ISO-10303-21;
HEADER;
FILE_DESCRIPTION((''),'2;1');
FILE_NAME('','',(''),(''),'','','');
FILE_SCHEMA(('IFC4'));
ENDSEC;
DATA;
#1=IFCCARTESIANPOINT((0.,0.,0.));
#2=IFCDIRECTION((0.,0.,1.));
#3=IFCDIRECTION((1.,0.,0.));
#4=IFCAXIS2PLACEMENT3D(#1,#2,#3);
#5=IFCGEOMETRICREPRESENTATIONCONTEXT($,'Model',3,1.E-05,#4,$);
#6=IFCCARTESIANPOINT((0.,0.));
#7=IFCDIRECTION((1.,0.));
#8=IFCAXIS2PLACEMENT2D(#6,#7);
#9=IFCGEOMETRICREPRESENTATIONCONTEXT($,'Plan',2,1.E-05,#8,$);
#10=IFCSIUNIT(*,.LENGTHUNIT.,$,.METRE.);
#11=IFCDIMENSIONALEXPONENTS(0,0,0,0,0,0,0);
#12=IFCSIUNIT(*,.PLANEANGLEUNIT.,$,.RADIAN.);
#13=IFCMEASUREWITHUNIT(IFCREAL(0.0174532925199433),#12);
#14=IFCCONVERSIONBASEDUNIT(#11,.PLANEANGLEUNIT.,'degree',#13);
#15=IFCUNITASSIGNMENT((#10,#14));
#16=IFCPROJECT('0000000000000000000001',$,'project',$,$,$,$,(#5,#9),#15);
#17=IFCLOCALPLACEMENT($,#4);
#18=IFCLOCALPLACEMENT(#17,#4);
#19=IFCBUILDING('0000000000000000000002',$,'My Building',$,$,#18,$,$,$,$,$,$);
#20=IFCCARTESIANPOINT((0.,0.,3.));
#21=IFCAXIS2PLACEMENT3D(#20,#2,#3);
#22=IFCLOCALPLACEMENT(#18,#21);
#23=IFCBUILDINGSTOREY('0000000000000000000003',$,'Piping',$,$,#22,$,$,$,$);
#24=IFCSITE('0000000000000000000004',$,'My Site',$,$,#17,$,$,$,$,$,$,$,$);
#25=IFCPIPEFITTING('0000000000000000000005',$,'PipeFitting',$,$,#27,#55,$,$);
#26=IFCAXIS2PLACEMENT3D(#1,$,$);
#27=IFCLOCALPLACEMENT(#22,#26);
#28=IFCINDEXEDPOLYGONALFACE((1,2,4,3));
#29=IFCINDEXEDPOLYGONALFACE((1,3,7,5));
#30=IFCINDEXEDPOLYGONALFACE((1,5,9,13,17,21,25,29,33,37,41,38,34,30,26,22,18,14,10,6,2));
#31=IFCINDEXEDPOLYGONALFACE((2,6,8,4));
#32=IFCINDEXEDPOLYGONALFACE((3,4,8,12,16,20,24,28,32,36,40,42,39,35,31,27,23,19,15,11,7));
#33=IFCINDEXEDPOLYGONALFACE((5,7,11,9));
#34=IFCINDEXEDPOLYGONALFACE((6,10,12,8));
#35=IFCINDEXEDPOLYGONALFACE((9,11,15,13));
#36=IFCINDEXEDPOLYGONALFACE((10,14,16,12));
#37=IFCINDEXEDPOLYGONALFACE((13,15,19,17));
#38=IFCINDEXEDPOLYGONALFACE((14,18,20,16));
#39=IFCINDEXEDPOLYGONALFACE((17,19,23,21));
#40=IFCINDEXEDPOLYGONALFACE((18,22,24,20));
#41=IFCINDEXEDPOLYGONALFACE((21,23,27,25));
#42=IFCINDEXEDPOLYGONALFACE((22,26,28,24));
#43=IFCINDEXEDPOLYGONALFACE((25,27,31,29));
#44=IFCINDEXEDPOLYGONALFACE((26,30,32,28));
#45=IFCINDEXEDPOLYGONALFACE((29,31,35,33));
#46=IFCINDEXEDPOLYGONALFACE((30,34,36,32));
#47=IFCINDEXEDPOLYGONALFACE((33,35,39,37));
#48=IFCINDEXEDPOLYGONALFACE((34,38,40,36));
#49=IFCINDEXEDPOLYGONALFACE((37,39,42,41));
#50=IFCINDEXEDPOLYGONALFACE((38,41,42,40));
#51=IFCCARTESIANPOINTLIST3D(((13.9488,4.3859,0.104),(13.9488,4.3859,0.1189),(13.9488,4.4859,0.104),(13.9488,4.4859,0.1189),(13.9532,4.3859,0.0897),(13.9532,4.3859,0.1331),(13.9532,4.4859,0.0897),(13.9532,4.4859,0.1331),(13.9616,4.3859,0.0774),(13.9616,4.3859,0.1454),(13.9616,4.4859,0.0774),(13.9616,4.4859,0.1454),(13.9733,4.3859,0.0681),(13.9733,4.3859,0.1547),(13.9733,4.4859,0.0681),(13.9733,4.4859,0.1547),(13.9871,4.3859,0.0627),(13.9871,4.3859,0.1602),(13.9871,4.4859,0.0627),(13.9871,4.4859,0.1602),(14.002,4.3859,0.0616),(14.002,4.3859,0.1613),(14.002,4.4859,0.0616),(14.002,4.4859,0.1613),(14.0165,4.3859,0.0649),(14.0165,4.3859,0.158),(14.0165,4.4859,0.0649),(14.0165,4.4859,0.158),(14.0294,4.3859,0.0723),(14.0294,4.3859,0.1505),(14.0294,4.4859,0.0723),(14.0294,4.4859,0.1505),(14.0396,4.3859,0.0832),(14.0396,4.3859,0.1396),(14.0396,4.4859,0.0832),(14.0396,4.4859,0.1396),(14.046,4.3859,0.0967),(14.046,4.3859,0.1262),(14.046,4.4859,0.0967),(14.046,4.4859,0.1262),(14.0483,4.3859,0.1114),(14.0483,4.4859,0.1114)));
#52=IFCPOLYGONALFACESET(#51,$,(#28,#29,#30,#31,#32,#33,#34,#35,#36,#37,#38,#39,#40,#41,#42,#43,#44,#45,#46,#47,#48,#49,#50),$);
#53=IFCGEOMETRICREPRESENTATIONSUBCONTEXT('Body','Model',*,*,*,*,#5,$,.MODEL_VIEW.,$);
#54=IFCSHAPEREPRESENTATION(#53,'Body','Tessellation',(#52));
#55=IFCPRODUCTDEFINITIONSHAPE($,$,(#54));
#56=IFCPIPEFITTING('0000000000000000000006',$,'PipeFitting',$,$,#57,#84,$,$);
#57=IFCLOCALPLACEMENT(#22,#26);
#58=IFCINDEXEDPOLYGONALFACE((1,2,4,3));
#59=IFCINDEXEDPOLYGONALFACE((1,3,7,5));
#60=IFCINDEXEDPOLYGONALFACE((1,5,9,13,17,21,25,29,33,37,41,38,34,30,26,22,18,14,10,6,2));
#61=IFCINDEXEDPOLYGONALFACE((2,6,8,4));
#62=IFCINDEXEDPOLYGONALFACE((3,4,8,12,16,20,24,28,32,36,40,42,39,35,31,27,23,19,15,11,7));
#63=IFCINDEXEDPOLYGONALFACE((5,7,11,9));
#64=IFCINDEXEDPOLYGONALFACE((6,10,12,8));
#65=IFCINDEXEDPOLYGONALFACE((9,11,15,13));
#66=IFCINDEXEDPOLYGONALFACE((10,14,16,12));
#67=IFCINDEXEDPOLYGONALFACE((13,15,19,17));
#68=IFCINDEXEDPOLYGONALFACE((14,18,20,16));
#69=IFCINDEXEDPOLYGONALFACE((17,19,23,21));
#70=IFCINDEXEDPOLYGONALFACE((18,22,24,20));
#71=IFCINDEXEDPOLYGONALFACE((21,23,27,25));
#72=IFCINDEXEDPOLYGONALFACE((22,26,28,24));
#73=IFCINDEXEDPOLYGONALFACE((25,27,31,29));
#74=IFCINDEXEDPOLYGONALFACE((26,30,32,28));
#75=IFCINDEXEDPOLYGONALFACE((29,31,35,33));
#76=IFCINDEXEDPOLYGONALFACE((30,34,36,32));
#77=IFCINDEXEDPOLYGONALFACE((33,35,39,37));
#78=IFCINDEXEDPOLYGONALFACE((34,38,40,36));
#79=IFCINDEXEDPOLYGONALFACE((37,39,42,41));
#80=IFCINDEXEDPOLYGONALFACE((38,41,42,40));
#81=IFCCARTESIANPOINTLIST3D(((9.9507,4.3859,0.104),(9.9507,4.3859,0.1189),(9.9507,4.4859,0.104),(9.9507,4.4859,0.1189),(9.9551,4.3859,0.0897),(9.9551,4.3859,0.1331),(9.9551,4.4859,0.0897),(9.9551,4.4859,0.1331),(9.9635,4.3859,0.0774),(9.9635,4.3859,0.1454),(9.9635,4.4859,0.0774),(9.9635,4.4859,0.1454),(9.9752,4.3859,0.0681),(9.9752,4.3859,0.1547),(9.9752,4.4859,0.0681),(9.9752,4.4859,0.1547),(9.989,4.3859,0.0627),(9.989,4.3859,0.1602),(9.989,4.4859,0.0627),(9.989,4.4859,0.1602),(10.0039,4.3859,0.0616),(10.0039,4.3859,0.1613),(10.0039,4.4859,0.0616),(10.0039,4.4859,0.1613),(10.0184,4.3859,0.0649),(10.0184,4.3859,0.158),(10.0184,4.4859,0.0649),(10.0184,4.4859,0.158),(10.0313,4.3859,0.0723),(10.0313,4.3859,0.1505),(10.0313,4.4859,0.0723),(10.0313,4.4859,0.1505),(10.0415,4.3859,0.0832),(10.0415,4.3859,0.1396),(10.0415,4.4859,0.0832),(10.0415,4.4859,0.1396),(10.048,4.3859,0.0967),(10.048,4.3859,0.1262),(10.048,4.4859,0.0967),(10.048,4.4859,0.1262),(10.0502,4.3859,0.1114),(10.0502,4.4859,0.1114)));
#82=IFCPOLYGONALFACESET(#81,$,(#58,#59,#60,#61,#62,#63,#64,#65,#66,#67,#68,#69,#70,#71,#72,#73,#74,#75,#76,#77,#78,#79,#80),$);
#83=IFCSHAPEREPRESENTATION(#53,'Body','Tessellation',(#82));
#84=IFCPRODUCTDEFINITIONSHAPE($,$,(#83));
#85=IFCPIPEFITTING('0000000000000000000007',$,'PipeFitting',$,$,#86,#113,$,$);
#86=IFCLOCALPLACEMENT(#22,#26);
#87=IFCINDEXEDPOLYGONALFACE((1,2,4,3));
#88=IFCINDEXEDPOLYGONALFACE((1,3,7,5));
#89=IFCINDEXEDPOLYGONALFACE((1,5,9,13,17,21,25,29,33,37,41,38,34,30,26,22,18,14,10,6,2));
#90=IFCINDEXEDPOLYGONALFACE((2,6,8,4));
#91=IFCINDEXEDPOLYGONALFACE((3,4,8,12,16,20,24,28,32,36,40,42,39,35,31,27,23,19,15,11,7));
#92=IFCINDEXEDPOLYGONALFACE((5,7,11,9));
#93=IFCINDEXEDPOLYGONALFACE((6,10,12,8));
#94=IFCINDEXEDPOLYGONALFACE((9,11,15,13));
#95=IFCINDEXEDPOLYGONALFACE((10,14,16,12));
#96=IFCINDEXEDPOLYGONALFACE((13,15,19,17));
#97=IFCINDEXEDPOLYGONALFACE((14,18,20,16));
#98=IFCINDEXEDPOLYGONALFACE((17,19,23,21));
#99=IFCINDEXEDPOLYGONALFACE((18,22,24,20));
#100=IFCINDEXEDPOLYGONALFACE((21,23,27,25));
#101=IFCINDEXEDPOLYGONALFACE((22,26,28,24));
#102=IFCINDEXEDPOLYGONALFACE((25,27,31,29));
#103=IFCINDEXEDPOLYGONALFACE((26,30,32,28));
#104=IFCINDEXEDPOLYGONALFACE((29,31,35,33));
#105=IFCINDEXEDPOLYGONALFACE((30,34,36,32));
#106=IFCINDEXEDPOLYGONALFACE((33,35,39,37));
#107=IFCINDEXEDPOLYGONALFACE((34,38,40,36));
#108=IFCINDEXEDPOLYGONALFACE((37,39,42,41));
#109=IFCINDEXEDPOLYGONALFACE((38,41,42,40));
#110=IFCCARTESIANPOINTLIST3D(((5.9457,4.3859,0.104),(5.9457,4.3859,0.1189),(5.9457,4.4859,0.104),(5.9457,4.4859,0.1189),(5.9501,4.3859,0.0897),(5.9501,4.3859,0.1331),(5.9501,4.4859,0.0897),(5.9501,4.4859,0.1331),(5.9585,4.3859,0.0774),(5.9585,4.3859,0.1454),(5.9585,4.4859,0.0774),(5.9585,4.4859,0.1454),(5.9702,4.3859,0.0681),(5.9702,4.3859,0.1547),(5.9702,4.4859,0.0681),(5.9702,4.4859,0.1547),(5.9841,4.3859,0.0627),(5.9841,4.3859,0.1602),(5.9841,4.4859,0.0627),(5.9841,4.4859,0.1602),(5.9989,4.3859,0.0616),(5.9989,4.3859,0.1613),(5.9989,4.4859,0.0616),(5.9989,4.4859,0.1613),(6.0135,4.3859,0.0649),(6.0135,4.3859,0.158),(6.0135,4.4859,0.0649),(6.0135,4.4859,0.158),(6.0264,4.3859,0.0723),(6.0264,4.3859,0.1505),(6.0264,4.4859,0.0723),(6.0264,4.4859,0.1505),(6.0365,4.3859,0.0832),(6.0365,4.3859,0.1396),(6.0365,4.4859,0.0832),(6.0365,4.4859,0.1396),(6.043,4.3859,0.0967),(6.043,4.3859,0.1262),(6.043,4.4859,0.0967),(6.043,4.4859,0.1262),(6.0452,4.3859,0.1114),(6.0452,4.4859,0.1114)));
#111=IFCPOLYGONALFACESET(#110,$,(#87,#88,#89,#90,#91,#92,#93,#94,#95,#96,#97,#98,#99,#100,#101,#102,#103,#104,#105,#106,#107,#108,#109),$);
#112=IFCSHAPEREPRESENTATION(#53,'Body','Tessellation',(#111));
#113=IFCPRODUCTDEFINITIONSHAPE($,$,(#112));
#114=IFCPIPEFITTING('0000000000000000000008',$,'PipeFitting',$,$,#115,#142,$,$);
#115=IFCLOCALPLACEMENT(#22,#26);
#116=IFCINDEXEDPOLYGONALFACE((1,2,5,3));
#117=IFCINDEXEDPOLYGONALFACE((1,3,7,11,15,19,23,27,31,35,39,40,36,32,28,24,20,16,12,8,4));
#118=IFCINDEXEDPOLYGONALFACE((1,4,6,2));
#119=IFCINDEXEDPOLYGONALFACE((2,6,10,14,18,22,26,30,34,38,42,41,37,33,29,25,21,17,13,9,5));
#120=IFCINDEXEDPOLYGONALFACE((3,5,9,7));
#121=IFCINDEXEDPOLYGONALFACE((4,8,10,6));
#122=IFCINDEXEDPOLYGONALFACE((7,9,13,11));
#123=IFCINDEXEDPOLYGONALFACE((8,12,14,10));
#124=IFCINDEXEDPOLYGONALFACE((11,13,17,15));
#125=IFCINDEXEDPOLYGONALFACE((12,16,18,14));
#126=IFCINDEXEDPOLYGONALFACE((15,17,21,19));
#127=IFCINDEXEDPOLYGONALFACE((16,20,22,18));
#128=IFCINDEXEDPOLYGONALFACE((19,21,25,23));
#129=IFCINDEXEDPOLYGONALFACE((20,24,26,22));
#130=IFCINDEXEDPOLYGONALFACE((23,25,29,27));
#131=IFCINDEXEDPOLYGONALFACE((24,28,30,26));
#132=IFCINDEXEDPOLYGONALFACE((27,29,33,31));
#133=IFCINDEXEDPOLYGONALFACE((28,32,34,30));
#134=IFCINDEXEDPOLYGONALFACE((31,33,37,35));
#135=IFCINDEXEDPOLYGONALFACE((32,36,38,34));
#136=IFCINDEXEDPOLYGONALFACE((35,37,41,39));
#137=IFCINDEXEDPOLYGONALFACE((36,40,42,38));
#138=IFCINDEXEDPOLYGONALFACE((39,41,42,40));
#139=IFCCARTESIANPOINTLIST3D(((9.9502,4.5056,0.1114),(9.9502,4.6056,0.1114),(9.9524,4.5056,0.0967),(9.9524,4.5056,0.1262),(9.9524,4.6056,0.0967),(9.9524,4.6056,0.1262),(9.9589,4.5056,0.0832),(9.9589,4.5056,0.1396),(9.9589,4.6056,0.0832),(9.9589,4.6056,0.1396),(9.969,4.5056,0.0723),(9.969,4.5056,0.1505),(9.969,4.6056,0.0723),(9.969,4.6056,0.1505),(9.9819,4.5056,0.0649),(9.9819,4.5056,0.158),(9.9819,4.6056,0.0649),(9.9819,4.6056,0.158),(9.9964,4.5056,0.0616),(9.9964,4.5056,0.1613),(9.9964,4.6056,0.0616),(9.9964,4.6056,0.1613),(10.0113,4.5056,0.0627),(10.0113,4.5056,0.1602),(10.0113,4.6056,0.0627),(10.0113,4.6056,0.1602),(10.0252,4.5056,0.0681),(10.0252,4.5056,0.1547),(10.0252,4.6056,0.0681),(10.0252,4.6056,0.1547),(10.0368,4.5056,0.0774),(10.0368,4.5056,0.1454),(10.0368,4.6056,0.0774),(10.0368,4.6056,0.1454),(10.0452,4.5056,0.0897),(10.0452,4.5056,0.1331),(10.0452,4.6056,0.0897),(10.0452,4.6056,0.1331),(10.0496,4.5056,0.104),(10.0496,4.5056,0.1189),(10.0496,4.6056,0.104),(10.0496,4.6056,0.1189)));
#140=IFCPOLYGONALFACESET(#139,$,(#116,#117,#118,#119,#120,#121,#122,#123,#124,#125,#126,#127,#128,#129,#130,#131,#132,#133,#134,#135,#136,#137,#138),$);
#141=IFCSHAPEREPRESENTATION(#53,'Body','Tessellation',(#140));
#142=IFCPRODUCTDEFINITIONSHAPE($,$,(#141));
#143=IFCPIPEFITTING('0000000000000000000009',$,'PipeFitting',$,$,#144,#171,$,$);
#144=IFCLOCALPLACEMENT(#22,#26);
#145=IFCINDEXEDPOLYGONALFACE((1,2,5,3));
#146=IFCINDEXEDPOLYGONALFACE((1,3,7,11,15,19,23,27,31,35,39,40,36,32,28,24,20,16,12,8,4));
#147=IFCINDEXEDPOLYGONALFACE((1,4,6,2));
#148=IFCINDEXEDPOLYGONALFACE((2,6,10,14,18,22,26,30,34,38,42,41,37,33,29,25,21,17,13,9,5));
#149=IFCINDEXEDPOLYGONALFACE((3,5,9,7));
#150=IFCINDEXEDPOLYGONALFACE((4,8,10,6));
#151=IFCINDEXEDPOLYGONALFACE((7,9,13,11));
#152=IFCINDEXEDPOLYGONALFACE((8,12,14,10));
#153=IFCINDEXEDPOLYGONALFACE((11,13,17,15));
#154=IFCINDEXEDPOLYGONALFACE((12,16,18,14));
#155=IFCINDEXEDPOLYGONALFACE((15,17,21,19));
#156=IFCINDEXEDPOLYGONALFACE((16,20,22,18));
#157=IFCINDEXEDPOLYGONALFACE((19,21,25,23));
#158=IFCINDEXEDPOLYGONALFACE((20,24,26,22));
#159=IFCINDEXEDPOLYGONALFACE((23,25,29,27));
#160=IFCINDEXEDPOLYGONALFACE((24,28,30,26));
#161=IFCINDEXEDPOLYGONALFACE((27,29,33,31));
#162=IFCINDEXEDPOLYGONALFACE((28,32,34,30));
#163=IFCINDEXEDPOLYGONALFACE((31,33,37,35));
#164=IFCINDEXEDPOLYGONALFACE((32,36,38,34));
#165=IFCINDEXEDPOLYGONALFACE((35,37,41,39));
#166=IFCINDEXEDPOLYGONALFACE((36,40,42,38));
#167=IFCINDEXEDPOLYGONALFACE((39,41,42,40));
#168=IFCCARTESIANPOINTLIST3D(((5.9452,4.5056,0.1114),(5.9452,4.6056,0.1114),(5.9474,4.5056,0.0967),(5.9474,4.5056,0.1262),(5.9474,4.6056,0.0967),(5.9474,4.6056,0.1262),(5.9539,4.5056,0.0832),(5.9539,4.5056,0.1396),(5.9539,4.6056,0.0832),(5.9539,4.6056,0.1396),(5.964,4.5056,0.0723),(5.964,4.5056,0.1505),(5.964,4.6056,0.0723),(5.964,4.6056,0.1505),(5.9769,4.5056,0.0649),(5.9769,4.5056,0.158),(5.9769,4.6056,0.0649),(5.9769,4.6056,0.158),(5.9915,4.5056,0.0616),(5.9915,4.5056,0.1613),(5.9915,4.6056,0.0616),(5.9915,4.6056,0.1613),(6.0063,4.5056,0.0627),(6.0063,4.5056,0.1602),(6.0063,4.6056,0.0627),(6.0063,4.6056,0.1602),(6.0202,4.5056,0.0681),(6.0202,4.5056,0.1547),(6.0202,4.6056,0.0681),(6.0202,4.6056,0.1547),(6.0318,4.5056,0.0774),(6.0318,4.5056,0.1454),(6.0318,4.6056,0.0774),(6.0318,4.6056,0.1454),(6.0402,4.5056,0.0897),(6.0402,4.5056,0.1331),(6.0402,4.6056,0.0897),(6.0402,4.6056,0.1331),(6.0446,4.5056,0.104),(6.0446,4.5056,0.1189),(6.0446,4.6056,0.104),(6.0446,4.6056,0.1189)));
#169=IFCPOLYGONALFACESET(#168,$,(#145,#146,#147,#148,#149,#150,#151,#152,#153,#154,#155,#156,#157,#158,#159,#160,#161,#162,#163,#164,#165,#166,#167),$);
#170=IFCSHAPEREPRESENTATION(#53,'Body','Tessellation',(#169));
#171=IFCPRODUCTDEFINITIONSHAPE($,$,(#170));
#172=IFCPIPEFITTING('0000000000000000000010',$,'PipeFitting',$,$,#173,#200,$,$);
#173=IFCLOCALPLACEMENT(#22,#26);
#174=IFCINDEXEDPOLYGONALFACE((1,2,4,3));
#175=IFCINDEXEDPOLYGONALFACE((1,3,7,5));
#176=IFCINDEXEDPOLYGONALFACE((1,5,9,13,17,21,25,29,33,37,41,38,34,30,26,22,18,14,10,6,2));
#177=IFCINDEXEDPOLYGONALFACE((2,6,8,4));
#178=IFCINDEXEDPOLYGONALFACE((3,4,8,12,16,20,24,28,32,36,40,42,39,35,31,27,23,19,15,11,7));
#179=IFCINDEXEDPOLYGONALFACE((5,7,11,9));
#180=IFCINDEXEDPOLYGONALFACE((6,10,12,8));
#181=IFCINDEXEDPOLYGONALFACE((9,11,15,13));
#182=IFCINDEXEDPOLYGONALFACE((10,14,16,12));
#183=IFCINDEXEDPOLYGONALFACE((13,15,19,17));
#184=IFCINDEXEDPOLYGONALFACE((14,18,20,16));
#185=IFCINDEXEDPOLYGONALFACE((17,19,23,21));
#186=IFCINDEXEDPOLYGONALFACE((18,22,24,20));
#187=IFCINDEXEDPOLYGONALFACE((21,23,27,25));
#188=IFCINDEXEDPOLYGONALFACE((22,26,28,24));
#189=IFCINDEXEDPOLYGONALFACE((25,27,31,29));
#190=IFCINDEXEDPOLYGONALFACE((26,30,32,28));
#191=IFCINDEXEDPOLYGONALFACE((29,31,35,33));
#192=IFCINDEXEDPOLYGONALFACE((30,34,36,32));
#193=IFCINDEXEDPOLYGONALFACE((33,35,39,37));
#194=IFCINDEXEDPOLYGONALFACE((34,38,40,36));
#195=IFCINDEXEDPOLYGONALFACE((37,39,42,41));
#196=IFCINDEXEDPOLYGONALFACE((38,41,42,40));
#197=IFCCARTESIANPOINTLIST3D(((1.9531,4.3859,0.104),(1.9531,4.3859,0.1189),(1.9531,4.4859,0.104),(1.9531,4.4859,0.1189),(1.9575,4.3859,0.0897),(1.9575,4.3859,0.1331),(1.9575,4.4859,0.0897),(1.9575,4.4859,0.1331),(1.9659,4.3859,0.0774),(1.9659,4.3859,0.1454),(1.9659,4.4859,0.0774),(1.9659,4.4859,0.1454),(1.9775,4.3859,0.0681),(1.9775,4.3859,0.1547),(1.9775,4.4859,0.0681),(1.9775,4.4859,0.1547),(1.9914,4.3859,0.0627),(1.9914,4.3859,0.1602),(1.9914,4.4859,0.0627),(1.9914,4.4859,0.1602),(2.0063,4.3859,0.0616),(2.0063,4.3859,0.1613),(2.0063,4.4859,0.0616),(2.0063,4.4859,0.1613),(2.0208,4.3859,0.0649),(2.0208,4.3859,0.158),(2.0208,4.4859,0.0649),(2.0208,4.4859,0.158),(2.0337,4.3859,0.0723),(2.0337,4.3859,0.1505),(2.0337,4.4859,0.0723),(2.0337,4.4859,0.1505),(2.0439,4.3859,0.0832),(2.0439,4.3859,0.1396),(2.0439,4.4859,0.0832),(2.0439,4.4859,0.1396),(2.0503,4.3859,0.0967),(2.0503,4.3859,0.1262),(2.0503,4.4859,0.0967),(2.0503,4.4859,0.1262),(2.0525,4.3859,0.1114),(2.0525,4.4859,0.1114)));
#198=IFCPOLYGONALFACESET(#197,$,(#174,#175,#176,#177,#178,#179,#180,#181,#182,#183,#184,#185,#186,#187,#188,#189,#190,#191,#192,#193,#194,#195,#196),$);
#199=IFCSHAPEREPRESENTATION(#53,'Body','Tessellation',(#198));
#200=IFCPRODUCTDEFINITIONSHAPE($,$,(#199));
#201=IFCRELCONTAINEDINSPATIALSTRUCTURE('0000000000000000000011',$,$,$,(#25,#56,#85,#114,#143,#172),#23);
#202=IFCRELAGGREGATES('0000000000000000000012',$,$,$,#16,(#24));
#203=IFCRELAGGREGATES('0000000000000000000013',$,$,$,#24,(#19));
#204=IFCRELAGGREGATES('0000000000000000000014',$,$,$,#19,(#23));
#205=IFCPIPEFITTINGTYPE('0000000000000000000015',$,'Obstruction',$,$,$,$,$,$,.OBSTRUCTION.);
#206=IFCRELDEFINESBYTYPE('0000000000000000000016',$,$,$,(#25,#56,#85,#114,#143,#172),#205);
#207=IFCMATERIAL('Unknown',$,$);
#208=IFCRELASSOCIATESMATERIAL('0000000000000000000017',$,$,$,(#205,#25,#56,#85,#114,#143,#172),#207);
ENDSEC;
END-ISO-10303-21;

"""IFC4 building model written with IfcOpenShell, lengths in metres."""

from ifc_helpers import new_model, entity, si_unit, converted_unit, frame, origin_with_axes, origin_2d_with_axis, place, context, subcontext, project, spatial, circle, extrude, material, material_profile, profile_set, profile_usage, type_object, element, save


model = new_model("IFC4")

# Units and contexts
model_context = context("Model", 3, precision=1e-05, world=origin_with_axes())
plan_context = context("Plan", 2, precision=1e-05, world=origin_2d_with_axis())
body_context = subcontext(model_context, "Body", "Model", "MODEL_VIEW")
ifc_project = project(units=[si_unit("LENGTHUNIT", "METRE"), converted_unit("PLANEANGLEUNIT", "degree", entity("IfcReal", 0.0174532925199433), si_unit("PLANEANGLEUNIT", "RADIAN"), dimensions=[0, 0, 0, 0, 0, 0, 0])], contexts=[model_context, plan_context])

# Site, building, storey
site_placement = place(None, origin_with_axes())
site = spatial("IfcSite", under=ifc_project, at=site_placement, Name="My Site")
building_placement = place(site_placement, origin_with_axes())
building = spatial("IfcBuilding", under=site, at=building_placement, Name="My Building")
storey_placement = place(building_placement, frame((0.0, 0.0, 3.0), z_axis=(0.0, 0.0, 1.0), x_axis=(1.0, 0.0, 0.0)))
storey = spatial("IfcBuildingStorey", under=building, at=storey_placement, Name="Piping")

# Shared definitions
ifc_material = material(Name="Unknown")

# Pipe fittings
ifc_material_profile_1 = material_profile(ifc_material, circle(Radius=0.05))
ifc_profile_set_1 = profile_set([ifc_material_profile_1])
pipe_fitting_type_1 = type_object("IfcPipeFittingType", Name="Obstruction", PredefinedType="OBSTRUCTION", material=ifc_profile_set_1)
ifc_profile_usage_1 = profile_usage(ifc_profile_set_1, cardinal=16)
pipe_fitting_1_placement = place(storey_placement, frame((13.9983, 4.4859, 0.1114), z_axis=(0.0, -1.0, 0.0), x_axis=(1.0, 0.0, 0.0)))
element("IfcPipeFitting", 1, at=pipe_fitting_1_placement, inside=storey, type_object=pipe_fitting_type_1, material=ifc_profile_usage_1, Name="PipeFitting", context=body_context, shape_type="SweptSolid", body=[
    extrude(circle(Radius=0.05), origin_with_axes(), (0.0, 0.0, 1.0), 0.1),
])
ifc_profile_usage_2 = profile_usage(ifc_profile_set_1, cardinal=16)
pipe_fitting_2_placement = place(storey_placement, frame((10.0002, 4.4859, 0.1114), z_axis=(0.0, -1.0, 0.0), x_axis=(1.0, 0.0, 0.0)))
element("IfcPipeFitting", 2, at=pipe_fitting_2_placement, inside=storey, type_object=pipe_fitting_type_1, material=ifc_profile_usage_2, Name="PipeFitting", context=body_context, shape_type="SweptSolid", body=[
    extrude(circle(Radius=0.05), origin_with_axes(), (0.0, 0.0, 1.0), 0.1),
])
ifc_profile_usage_3 = profile_usage(ifc_profile_set_1, cardinal=16)
pipe_fitting_3_placement = place(storey_placement, frame((5.9952, 4.4859, 0.1114), z_axis=(0.0, -1.0, 0.0), x_axis=(1.0, 0.0, 0.0)))
element("IfcPipeFitting", 3, at=pipe_fitting_3_placement, inside=storey, type_object=pipe_fitting_type_1, material=ifc_profile_usage_3, Name="PipeFitting", context=body_context, shape_type="SweptSolid", body=[
    extrude(circle(Radius=0.05), origin_with_axes(), (0.0, 0.0, 1.0), 0.1),
])
ifc_profile_usage_4 = profile_usage(ifc_profile_set_1, cardinal=16)
pipe_fitting_4_placement = place(storey_placement, frame((10.0002, 4.5056, 0.1114), z_axis=(0.0, 1.0, 0.0), x_axis=(-1.0, 0.0, 0.0)))
element("IfcPipeFitting", 4, at=pipe_fitting_4_placement, inside=storey, type_object=pipe_fitting_type_1, material=ifc_profile_usage_4, Name="PipeFitting", context=body_context, shape_type="SweptSolid", body=[
    extrude(circle(Radius=0.05), origin_with_axes(), (0.0, 0.0, 1.0), 0.1),
])
ifc_profile_usage_5 = profile_usage(ifc_profile_set_1, cardinal=16)
pipe_fitting_5_placement = place(storey_placement, frame((5.9952, 4.5056, 0.1114), z_axis=(0.0, 1.0, 0.0), x_axis=(-1.0, 0.0, 0.0)))
element("IfcPipeFitting", 5, at=pipe_fitting_5_placement, inside=storey, type_object=pipe_fitting_type_1, material=ifc_profile_usage_5, Name="PipeFitting", context=body_context, shape_type="SweptSolid", body=[
    extrude(circle(Radius=0.05), origin_with_axes(), (0.0, 0.0, 1.0), 0.1),
])
ifc_profile_usage_6 = profile_usage(ifc_profile_set_1, cardinal=16)
pipe_fitting_6_placement = place(storey_placement, frame((2.0025, 4.4859, 0.1114), z_axis=(0.0, -1.0, 0.0), x_axis=(1.0, 0.0, 0.0)))
element("IfcPipeFitting", 6, at=pipe_fitting_6_placement, inside=storey, type_object=pipe_fitting_type_1, material=ifc_profile_usage_6, Name="PipeFitting", context=body_context, shape_type="SweptSolid", body=[
    extrude(circle(Radius=0.05), origin_with_axes(), (0.0, 0.0, 1.0), 0.1),
])

save(model, "model.ifc")
